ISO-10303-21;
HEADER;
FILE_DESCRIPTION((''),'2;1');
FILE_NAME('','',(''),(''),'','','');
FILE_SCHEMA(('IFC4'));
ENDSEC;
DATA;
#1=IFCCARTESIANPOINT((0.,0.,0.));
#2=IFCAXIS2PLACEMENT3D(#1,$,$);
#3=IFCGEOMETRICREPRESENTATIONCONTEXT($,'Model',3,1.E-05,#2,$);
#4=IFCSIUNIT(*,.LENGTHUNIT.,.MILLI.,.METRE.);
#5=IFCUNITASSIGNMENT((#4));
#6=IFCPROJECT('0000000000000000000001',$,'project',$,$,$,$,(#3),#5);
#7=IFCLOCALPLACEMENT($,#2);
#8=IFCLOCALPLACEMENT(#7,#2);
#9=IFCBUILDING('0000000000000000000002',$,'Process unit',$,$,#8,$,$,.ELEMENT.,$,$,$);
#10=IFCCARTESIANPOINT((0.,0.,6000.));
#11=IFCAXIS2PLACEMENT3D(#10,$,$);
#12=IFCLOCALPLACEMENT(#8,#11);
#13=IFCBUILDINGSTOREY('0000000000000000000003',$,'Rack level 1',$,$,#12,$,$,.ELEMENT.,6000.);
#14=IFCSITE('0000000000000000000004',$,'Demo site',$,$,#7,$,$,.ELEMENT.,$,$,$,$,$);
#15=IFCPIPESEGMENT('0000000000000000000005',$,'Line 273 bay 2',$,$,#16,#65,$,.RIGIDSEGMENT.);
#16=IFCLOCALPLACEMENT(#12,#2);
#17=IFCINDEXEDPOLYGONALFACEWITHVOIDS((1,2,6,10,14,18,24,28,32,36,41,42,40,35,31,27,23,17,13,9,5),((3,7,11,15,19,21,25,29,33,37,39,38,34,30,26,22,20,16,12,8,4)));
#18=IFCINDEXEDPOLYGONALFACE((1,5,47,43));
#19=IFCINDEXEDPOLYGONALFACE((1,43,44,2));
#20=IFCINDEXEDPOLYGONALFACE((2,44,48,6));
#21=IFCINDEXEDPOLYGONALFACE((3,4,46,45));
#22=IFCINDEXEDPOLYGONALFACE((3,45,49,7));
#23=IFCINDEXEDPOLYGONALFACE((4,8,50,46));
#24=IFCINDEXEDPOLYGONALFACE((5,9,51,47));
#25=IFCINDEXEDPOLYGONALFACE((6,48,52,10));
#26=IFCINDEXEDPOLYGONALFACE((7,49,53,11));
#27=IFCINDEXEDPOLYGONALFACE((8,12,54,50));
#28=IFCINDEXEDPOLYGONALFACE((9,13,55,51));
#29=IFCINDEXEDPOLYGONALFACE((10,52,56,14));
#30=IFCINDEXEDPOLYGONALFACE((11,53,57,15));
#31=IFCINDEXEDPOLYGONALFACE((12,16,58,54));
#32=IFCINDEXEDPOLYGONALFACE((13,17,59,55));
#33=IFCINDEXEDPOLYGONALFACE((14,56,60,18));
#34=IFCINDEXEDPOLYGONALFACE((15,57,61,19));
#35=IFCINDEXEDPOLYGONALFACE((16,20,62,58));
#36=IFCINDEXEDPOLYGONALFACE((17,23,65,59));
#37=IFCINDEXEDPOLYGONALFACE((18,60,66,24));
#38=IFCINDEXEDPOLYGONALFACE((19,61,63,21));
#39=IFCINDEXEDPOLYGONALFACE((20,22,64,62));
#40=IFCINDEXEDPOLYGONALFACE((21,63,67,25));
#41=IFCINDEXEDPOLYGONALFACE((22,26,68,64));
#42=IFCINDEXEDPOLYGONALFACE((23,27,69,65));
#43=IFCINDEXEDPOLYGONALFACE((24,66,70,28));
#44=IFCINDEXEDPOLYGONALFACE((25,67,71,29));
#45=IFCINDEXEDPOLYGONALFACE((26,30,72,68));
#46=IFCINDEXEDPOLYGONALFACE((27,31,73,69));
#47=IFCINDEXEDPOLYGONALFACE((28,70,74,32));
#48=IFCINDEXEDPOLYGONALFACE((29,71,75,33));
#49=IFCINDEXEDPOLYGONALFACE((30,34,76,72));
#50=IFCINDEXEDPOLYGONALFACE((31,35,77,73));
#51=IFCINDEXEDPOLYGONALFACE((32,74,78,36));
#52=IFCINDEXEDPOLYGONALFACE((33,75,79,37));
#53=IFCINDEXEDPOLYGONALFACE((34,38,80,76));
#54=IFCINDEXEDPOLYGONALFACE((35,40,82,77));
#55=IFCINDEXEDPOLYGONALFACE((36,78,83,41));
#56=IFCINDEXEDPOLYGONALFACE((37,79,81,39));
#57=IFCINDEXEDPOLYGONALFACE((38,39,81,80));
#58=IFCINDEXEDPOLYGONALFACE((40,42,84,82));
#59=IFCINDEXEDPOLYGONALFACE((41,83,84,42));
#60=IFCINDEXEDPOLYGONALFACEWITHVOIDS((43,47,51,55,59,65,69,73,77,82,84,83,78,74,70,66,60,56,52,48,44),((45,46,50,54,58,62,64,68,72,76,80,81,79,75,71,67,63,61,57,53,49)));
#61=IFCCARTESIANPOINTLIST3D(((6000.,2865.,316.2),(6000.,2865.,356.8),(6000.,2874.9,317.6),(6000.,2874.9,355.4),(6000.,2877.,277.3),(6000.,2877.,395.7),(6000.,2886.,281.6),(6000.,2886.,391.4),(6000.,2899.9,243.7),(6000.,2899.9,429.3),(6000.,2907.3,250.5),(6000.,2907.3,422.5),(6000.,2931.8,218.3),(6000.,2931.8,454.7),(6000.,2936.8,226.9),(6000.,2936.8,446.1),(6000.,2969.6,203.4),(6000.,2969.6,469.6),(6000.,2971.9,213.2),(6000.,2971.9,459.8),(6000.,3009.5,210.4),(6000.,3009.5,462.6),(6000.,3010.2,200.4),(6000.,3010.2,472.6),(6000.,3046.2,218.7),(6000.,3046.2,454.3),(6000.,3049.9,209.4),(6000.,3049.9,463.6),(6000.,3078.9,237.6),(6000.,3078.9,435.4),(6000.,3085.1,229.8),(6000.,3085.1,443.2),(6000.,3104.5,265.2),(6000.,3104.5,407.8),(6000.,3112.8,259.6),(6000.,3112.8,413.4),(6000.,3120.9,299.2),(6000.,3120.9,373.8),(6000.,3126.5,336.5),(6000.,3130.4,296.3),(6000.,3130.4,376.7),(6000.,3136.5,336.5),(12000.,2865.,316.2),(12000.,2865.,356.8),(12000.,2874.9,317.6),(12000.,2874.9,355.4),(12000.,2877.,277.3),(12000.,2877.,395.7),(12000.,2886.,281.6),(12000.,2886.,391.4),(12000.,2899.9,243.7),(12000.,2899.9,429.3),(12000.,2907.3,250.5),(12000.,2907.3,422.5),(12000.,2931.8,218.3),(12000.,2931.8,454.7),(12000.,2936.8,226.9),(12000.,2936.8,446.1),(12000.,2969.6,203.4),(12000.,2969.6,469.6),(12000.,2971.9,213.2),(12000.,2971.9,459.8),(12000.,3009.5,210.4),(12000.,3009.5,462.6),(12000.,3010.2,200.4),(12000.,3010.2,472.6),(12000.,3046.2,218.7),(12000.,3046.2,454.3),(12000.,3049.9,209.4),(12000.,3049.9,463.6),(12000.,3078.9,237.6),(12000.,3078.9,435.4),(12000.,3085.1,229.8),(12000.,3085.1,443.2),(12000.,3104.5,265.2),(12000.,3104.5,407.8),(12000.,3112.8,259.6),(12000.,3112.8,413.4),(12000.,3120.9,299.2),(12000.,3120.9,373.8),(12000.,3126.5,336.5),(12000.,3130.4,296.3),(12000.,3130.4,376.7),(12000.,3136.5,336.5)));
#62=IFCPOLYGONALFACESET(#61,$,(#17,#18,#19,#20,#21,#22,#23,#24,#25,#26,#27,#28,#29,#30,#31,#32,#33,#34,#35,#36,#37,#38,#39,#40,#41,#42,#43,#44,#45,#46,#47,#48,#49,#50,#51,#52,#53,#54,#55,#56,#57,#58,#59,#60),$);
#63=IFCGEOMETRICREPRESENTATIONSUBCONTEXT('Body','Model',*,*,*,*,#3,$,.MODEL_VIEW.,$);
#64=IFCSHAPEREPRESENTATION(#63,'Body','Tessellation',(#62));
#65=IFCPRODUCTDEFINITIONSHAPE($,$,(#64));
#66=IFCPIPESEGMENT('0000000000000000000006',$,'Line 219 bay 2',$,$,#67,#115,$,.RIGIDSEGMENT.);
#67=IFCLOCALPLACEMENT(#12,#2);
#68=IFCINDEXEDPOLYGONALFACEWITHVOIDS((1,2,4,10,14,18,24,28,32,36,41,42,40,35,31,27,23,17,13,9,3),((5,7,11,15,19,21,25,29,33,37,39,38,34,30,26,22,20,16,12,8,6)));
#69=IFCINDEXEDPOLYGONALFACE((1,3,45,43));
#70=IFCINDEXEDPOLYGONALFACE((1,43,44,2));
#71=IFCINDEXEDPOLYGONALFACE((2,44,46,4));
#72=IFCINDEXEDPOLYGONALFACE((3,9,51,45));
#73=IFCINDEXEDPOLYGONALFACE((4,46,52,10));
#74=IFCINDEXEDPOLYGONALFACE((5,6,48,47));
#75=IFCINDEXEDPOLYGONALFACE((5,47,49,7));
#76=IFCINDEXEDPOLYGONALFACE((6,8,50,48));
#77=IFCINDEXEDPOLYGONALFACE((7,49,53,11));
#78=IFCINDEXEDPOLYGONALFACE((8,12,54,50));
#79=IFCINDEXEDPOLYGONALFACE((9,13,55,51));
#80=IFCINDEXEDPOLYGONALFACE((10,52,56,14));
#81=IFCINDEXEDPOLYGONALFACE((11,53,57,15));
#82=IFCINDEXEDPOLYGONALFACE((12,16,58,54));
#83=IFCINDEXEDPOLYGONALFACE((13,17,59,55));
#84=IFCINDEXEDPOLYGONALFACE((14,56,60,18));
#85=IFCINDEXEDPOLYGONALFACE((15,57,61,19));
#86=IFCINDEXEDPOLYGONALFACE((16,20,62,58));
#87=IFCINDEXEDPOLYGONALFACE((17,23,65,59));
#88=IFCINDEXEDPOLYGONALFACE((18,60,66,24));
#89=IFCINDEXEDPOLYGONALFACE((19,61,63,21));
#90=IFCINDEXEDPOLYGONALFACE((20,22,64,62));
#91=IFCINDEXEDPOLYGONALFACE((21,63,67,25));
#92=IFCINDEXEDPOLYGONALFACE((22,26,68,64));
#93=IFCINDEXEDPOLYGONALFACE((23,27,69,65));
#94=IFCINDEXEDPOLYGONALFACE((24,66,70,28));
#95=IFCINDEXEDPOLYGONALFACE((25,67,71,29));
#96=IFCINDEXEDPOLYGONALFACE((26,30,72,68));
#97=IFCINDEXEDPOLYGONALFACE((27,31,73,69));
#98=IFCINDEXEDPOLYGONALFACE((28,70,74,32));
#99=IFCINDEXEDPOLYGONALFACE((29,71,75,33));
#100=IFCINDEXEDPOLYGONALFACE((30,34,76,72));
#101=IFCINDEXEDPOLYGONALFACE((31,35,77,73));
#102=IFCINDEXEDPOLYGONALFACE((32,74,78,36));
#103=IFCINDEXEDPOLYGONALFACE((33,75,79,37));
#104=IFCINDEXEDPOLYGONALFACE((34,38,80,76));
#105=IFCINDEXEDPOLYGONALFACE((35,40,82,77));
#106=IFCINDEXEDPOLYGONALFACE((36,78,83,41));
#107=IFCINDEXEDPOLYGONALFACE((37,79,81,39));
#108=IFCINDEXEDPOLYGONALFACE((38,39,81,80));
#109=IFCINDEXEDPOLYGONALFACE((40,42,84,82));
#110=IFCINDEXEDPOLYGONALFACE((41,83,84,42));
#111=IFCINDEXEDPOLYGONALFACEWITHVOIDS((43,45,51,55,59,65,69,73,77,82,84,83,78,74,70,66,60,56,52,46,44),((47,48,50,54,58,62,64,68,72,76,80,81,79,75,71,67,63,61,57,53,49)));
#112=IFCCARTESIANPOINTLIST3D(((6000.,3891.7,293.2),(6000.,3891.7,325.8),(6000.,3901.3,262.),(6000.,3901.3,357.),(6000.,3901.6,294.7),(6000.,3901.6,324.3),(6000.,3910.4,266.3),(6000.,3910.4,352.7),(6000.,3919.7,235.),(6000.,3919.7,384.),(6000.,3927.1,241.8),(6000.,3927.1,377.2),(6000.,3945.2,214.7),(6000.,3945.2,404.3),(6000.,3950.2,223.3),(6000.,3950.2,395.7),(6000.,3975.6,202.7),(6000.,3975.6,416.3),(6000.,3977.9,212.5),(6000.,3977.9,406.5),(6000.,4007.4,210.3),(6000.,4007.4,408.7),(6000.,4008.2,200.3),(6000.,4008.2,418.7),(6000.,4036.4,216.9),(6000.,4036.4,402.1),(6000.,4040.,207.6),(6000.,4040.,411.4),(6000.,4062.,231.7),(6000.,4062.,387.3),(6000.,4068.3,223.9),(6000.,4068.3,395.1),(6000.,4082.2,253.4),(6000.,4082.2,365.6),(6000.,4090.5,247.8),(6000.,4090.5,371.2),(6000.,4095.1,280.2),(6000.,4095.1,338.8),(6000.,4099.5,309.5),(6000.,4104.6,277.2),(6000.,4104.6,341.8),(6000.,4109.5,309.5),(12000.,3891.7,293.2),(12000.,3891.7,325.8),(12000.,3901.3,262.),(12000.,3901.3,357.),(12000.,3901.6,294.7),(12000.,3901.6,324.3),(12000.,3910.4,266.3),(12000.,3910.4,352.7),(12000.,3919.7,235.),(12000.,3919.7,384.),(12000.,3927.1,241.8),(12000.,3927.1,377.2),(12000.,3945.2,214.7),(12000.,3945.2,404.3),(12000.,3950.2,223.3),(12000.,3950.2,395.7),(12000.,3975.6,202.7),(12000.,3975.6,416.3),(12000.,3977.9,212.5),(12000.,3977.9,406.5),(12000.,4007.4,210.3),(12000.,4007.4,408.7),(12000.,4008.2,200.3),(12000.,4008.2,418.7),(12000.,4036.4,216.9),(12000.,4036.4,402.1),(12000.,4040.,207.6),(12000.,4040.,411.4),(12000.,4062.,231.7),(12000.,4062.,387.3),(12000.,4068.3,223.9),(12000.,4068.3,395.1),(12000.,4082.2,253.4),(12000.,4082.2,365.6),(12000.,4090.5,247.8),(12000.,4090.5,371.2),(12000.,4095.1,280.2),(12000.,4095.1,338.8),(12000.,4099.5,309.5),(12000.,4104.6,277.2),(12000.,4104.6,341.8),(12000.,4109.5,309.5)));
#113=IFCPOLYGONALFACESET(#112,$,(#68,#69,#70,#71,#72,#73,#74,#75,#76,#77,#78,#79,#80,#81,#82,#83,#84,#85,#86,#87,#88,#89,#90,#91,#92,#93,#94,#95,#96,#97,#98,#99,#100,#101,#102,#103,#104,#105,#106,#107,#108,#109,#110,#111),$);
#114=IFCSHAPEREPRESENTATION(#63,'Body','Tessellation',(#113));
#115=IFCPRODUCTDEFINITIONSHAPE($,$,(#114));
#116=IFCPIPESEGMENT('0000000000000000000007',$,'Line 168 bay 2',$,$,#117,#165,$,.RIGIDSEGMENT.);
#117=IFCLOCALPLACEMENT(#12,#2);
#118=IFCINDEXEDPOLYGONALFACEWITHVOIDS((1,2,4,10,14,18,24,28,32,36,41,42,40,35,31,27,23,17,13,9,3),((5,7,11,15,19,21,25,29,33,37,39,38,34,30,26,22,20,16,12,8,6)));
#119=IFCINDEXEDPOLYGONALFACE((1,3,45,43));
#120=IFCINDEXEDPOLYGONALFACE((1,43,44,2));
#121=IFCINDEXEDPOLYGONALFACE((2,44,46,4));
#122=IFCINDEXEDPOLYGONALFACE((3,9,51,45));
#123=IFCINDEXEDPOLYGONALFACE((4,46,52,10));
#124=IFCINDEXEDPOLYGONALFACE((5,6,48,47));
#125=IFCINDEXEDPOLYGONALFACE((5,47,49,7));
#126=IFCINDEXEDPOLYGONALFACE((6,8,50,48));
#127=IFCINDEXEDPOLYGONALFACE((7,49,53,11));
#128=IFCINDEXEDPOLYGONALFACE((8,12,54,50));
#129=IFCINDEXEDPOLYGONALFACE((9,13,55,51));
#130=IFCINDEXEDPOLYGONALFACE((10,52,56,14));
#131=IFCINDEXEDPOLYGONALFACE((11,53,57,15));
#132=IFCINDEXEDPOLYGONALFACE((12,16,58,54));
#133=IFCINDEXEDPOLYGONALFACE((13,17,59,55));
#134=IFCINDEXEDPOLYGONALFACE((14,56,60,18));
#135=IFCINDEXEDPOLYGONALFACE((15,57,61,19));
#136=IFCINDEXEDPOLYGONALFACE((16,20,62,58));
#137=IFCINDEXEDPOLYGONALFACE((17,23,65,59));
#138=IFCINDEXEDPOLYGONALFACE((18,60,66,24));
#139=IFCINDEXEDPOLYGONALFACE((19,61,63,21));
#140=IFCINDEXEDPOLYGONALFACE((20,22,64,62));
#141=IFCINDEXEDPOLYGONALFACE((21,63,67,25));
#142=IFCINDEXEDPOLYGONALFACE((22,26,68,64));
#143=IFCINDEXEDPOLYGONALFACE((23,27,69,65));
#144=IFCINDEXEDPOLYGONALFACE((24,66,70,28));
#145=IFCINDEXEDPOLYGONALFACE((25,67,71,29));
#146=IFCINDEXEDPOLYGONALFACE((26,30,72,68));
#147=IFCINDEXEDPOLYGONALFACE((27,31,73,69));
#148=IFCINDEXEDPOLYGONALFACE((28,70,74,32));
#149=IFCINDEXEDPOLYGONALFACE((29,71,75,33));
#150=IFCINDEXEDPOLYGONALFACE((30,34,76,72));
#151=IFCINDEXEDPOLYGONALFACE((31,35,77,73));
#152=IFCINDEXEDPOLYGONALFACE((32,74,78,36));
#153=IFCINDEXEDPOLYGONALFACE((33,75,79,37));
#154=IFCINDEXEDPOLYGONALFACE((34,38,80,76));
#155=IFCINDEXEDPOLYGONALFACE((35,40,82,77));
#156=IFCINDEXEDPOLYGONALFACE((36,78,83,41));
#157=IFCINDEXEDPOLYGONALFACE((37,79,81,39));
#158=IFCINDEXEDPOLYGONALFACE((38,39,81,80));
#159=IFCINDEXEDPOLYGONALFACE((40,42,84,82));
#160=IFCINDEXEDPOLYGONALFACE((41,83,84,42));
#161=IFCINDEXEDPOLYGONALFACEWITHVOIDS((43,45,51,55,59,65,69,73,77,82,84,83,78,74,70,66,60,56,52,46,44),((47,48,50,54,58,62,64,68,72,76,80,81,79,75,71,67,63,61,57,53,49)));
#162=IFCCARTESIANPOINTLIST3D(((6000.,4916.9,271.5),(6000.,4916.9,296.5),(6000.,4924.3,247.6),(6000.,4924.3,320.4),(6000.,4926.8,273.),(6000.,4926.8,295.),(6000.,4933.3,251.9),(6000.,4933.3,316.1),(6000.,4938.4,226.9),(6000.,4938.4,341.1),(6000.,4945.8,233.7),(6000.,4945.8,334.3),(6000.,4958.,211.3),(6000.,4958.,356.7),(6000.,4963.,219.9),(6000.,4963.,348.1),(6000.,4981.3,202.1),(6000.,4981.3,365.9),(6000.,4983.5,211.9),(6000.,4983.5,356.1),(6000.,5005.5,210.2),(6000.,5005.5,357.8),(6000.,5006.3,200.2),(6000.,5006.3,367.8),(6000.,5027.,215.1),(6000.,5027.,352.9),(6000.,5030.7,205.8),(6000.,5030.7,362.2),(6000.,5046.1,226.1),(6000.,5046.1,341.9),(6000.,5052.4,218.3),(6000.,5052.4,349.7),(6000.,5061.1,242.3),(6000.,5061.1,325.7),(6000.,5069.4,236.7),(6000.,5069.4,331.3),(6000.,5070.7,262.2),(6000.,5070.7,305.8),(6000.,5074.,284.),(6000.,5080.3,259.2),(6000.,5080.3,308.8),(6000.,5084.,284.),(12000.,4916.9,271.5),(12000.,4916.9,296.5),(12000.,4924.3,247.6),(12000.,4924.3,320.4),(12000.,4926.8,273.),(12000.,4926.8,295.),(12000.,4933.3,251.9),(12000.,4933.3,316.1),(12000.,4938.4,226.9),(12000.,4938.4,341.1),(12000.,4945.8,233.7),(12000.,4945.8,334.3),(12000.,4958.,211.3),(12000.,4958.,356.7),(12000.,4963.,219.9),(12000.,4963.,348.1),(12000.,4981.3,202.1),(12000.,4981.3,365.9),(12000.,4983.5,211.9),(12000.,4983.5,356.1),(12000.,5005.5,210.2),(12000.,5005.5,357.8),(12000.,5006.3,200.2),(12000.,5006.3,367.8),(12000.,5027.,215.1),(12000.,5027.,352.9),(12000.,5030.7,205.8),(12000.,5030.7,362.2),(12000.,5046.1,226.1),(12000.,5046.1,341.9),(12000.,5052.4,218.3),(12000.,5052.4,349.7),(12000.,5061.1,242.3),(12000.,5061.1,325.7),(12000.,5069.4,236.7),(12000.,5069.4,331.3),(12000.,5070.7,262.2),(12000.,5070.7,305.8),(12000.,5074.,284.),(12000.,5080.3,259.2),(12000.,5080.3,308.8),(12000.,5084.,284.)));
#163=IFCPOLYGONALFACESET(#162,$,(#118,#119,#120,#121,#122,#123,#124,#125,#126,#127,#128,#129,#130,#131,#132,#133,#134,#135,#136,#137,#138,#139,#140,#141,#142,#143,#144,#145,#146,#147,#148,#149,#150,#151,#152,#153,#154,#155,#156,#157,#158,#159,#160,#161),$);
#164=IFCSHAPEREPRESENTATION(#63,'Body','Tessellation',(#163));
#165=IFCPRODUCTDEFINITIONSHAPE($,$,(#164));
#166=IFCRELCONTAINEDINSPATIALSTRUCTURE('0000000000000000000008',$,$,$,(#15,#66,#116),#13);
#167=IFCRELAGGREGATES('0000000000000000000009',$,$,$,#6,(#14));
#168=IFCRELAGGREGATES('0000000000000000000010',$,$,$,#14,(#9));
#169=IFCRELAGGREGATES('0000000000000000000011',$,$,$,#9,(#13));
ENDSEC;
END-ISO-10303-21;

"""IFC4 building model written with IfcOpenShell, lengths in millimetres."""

from ifc_helpers import new_model, si_unit, frame, origin, place, context, subcontext, project, spatial, hollow_circle, extrude, element, save


model = new_model("IFC4")

# Units and contexts
model_context = context("Model", 3, precision=1e-05, world=origin())
body_context = subcontext(model_context, "Body", "Model", "MODEL_VIEW")
ifc_project = project(units=[si_unit("LENGTHUNIT", "METRE", prefix="MILLI")], contexts=[model_context])

# Site, building, storey
site_placement = place(None, origin())
site = spatial("IfcSite", under=ifc_project, at=site_placement, Name="Demo site", CompositionType="ELEMENT")
building_placement = place(site_placement, origin())
building = spatial("IfcBuilding", under=site, at=building_placement, Name="Process unit", CompositionType="ELEMENT")
storey_placement = place(building_placement, frame((0.0, 0.0, 6000.0)))
storey = spatial("IfcBuildingStorey", under=building, at=storey_placement, Name="Rack level 1", CompositionType="ELEMENT", Elevation=6000.0)

# Pipe segments
pipe_segment_1_placement = place(storey_placement, frame((6000.0, 3000.0, 336.5)))
element("IfcPipeSegment", 1, at=pipe_segment_1_placement, inside=storey, Name="Line 273 bay 2", PredefinedType="RIGIDSEGMENT", context=body_context, shape_type="SweptSolid", body=[
    extrude(hollow_circle(Radius=136.5, WallThickness=10.0), frame((0.0, 0.0, 0.0), z_axis=(1.0, 0.0, 0.0), x_axis=(0.0, 1.0, 0.0)), (0.0, 0.0, 1.0), 6000.0),
])
pipe_segment_2_placement = place(storey_placement, frame((6000.0, 4000.0, 309.5)))
element("IfcPipeSegment", 2, at=pipe_segment_2_placement, inside=storey, Name="Line 219 bay 2", PredefinedType="RIGIDSEGMENT", context=body_context, shape_type="SweptSolid", body=[
    extrude(hollow_circle(Radius=109.5, WallThickness=10.0), frame((0.0, 0.0, 0.0), z_axis=(1.0, 0.0, 0.0), x_axis=(0.0, 1.0, 0.0)), (0.0, 0.0, 1.0), 6000.0),
])
pipe_segment_3_placement = place(storey_placement, frame((6000.0, 5000.0, 284.0)))
element("IfcPipeSegment", 3, at=pipe_segment_3_placement, inside=storey, Name="Line 168 bay 2", PredefinedType="RIGIDSEGMENT", context=body_context, shape_type="SweptSolid", body=[
    extrude(hollow_circle(Radius=84.0, WallThickness=10.0), frame((0.0, 0.0, 0.0), z_axis=(1.0, 0.0, 0.0), x_axis=(0.0, 1.0, 0.0)), (0.0, 0.0, 1.0), 6000.0),
])

save(model, "model.ifc")
